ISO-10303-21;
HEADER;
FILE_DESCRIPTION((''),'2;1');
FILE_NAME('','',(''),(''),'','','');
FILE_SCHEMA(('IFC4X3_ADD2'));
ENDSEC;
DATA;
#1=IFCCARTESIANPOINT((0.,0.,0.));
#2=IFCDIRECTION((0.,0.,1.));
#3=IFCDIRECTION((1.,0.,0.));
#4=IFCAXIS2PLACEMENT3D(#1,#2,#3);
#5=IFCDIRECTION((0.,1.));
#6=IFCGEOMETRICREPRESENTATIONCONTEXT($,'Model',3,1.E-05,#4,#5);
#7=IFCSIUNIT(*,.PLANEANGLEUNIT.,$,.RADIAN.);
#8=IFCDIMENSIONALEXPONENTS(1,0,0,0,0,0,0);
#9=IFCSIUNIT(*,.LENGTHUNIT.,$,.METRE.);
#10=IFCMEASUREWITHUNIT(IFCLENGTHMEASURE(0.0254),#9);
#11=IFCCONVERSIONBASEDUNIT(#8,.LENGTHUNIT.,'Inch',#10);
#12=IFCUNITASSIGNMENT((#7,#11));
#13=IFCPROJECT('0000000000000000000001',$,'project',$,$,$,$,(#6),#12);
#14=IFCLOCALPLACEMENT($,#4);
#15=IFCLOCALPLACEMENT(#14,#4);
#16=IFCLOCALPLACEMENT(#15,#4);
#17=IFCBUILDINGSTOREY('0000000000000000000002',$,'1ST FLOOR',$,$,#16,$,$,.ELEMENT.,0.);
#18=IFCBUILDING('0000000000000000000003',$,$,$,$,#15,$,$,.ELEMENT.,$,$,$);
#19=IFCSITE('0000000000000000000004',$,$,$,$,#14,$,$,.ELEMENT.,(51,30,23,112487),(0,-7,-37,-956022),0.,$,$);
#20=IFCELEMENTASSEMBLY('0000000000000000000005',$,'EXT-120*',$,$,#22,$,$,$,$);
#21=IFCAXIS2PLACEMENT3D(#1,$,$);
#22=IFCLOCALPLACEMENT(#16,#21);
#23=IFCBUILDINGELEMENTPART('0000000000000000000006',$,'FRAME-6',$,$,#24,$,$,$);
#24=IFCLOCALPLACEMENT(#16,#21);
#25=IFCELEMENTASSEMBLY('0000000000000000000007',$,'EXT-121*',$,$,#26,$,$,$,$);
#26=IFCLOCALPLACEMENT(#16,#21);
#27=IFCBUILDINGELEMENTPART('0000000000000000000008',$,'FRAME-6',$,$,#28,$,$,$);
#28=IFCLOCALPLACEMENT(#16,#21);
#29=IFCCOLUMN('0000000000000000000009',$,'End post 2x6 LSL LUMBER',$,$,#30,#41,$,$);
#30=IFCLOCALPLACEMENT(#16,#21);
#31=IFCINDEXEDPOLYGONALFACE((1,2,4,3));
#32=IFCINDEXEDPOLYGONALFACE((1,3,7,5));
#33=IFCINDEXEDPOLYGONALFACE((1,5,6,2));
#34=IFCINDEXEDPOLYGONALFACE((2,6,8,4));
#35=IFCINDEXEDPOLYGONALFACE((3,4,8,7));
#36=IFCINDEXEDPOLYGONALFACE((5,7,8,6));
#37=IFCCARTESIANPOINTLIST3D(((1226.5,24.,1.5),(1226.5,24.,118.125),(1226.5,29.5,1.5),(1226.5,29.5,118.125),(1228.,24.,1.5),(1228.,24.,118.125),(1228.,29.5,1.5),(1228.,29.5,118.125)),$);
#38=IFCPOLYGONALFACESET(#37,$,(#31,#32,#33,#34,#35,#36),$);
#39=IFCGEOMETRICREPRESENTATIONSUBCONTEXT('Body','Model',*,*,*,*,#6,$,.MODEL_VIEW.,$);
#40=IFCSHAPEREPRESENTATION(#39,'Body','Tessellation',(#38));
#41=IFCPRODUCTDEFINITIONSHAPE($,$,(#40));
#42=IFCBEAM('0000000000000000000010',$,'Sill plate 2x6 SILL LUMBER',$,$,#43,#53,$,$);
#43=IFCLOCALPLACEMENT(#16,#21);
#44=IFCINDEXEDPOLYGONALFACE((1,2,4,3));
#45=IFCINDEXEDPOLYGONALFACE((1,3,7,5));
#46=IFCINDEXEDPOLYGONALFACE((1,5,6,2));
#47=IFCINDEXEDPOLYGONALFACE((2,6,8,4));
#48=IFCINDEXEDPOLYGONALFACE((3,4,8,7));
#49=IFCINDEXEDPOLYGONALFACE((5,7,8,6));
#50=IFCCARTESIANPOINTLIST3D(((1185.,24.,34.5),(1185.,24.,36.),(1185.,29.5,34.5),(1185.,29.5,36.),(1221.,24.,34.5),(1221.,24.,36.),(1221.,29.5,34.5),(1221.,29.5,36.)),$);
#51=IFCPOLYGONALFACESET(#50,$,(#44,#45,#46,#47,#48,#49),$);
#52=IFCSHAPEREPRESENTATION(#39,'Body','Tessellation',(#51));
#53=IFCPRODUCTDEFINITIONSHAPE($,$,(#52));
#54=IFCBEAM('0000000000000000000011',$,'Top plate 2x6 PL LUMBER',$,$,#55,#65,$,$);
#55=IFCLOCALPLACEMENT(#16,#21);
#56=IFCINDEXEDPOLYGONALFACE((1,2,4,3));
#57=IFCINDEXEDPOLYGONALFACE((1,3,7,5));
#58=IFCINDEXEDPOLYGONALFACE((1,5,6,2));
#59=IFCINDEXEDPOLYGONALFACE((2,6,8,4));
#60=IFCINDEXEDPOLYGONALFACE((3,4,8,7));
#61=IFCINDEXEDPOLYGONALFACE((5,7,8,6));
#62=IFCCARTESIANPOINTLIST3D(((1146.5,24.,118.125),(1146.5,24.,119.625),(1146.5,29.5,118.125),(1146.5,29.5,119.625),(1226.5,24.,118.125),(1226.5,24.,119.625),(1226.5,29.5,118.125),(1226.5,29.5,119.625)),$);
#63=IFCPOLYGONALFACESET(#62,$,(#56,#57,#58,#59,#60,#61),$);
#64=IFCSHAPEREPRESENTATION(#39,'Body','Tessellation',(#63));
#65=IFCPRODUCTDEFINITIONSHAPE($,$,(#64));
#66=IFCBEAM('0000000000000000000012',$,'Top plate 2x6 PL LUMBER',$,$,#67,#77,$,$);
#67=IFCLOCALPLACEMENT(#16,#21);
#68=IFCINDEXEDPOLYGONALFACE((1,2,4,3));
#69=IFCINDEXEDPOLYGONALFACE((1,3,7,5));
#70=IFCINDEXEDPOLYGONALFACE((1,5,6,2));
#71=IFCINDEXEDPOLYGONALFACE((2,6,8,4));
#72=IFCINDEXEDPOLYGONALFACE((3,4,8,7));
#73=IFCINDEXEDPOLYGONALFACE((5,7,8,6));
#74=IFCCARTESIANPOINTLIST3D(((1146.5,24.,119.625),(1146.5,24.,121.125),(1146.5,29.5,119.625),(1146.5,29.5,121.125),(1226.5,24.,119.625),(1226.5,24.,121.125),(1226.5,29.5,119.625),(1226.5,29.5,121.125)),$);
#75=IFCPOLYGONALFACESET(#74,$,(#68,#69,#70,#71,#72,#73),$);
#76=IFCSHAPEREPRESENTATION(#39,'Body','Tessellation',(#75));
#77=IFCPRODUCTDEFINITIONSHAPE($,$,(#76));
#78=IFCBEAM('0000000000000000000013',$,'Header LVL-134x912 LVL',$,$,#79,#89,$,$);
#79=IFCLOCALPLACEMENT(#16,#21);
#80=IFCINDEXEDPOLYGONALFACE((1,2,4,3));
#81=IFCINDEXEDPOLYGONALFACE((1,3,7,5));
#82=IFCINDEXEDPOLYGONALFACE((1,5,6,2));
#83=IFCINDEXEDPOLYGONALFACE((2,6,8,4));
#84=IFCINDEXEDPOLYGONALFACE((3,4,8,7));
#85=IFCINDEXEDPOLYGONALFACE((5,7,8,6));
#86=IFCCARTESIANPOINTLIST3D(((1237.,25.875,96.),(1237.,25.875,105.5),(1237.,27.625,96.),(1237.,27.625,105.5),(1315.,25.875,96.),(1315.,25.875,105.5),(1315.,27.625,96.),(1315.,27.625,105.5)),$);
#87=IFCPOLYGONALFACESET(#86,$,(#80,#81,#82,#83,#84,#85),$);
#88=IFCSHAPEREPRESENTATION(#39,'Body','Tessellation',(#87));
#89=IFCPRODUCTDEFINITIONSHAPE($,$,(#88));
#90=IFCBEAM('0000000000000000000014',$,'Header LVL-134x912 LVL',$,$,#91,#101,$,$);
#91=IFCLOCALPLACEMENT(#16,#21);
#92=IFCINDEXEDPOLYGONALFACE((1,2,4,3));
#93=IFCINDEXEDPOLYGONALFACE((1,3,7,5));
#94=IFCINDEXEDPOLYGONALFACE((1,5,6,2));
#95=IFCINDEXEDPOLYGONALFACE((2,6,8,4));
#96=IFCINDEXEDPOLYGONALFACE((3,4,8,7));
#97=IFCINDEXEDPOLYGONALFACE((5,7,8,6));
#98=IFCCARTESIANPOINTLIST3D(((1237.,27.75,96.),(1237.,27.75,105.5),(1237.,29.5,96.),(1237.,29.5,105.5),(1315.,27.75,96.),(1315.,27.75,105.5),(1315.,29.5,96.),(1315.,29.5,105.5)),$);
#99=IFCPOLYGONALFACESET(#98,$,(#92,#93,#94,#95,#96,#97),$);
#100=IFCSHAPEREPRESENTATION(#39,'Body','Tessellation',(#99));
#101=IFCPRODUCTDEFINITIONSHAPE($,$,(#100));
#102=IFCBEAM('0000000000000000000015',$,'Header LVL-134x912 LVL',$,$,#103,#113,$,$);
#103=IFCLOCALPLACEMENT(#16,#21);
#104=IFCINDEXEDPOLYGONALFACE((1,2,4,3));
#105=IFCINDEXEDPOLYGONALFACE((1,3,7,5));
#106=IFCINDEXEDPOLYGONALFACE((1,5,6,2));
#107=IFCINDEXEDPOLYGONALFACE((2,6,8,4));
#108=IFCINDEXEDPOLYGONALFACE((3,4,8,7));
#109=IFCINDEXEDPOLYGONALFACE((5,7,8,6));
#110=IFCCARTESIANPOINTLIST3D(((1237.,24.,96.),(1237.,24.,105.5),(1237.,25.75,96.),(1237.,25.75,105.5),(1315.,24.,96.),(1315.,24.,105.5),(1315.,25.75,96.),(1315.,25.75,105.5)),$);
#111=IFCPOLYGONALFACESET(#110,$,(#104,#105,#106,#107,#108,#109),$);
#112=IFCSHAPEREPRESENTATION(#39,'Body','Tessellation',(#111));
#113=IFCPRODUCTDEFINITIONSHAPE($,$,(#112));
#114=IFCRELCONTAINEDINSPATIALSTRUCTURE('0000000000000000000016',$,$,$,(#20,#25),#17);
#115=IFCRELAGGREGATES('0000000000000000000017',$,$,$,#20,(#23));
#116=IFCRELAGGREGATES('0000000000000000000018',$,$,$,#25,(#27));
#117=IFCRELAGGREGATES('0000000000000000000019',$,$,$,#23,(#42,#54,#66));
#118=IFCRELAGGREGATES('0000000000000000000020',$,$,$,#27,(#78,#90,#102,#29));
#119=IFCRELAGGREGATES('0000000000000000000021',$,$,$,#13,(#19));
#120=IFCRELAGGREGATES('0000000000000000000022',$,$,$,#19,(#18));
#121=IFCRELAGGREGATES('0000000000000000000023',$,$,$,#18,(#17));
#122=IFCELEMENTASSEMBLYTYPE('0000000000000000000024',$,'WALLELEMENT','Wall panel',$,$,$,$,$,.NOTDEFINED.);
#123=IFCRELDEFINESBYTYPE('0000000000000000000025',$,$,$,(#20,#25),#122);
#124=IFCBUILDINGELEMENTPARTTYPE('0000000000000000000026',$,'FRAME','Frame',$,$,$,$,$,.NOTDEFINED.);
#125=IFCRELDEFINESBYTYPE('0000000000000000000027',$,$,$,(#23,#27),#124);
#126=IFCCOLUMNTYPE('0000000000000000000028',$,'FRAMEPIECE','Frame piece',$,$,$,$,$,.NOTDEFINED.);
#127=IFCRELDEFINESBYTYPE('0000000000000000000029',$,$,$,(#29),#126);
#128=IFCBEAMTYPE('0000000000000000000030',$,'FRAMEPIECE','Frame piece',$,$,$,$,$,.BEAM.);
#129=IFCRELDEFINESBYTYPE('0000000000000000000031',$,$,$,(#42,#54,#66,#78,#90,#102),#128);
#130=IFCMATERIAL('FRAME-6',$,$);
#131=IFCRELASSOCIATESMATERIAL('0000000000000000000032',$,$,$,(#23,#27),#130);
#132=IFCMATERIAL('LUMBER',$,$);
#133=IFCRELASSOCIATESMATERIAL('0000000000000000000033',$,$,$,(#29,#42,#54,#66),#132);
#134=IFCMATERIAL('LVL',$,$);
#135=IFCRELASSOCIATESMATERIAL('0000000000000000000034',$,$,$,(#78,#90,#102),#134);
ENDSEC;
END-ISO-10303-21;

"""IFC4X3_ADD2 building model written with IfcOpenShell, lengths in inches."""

from ifc_helpers import new_model, entity, si_unit, converted_unit, direction, frame, origin_with_axes, origin_2d_with_axis, place, context, subcontext, project, spatial, rectangle, extrude, material, type_object, element, aggregate, save


model = new_model("IFC4X3_ADD2")

# Units and contexts
model_context = context("Model", 3, precision=1e-05, world=origin_with_axes(), true_north=direction((0.0, 1.0)))
body_context = subcontext(model_context, "Body", "Model", "MODEL_VIEW")
ifc_project = project(units=[si_unit("PLANEANGLEUNIT", "RADIAN"), converted_unit("LENGTHUNIT", "Inch", entity("IfcLengthMeasure", 0.0254), si_unit("LENGTHUNIT", "METRE"), dimensions=[1, 0, 0, 0, 0, 0, 0])], contexts=[model_context])

# Site, building, storey
site_placement = place(None, origin_with_axes())
site = spatial("IfcSite", under=ifc_project, at=site_placement, CompositionType="ELEMENT", RefLatitude=(51, 30, 23, 112487), RefLongitude=(0, -7, -37, -956022), RefElevation=0.0)
building_placement = place(site_placement, origin_with_axes())
building = spatial("IfcBuilding", under=site, at=building_placement, CompositionType="ELEMENT")
storey_placement = place(building_placement, origin_with_axes())
storey = spatial("IfcBuildingStorey", under=building, at=storey_placement, Name="1ST FLOOR", CompositionType="ELEMENT", Elevation=0.0)

# Element assemblies, building element parts, column
element_assembly_type = type_object("IfcElementAssemblyType", Name="WALLELEMENT", Description="Wall panel", PredefinedType="NOTDEFINED")
assembly_1_placement = place(storey_placement, origin_with_axes())
assembly_1 = element("IfcElementAssembly", 1, at=assembly_1_placement, inside=storey, type_object=element_assembly_type, Name="EXT-120*")
ifc_material_1 = material(Name="FRAME-6")
building_element_part_type = type_object("IfcBuildingElementPartType", Name="FRAME", Description="Frame", PredefinedType="NOTDEFINED")
building_element_part_1_placement = place(storey_placement, origin_with_axes())
building_element_part_1 = element("IfcBuildingElementPart", 2, at=building_element_part_1_placement, type_object=building_element_part_type, material=ifc_material_1, Name="FRAME-6")
aggregate(assembly_1, [building_element_part_1])
ifc_material_2 = material(Name="LUMBER")
column_type = type_object("IfcColumnType", Name="FRAMEPIECE", Description="Frame piece", PredefinedType="NOTDEFINED")
assembly_2_placement = place(storey_placement, origin_with_axes())
assembly_2 = element("IfcElementAssembly", 3, at=assembly_2_placement, inside=storey, type_object=element_assembly_type, Name="EXT-121*")
building_element_part_2_placement = place(storey_placement, origin_with_axes())
building_element_part_2 = element("IfcBuildingElementPart", 4, at=building_element_part_2_placement, type_object=building_element_part_type, material=ifc_material_1, Name="FRAME-6")
aggregate(assembly_2, [building_element_part_2])
column_1_placement = place(storey_placement, frame((1227.25, 26.75, 118.125), z_axis=(0.0, 0.0, -1.0), x_axis=(1.0, 0.0, 0.0)))
column_1 = element("IfcColumn", 5, at=column_1_placement, type_object=column_type, material=ifc_material_2, Name="End post 2x6 LSL LUMBER", context=body_context, shape_type="SweptSolid", body=[
    extrude(rectangle(XDim=1.5, YDim=5.5, at=origin_2d_with_axis()), origin_with_axes(), (0.0, 0.0, 1.0), 116.625),
])

# Beams
beam_type = type_object("IfcBeamType", Name="FRAMEPIECE", Description="Frame piece", PredefinedType="BEAM")
beam_1_placement = place(storey_placement, frame((1221.0, 26.75, 35.25), z_axis=(-1.0, 0.0, 0.0), x_axis=(0.0, 0.0, -1.0)))
beam_1 = element("IfcBeam", 6, at=beam_1_placement, type_object=beam_type, material=ifc_material_2, Name="Sill plate 2x6 SILL LUMBER", context=body_context, shape_type="SweptSolid", body=[
    extrude(rectangle(XDim=1.5, YDim=5.5, at=origin_2d_with_axis()), origin_with_axes(), (0.0, 0.0, 1.0), 36.0),
])
beam_2_placement = place(storey_placement, frame((1226.5, 26.75, 118.875), z_axis=(-1.0, 0.0, 0.0), x_axis=(0.0, 0.0, -1.0)))
beam_2 = element("IfcBeam", 7, at=beam_2_placement, type_object=beam_type, material=ifc_material_2, Name="Top plate 2x6 PL LUMBER", context=body_context, shape_type="SweptSolid", body=[
    extrude(rectangle(XDim=1.5, YDim=5.5, at=origin_2d_with_axis()), origin_with_axes(), (0.0, 0.0, 1.0), 80.0),
])
beam_3_placement = place(storey_placement, frame((1226.5, 26.75, 120.375), z_axis=(-1.0, 0.0, 0.0), x_axis=(0.0, 0.0, -1.0)))
beam_3 = element("IfcBeam", 8, at=beam_3_placement, type_object=beam_type, material=ifc_material_2, Name="Top plate 2x6 PL LUMBER", context=body_context, shape_type="SweptSolid", body=[
    extrude(rectangle(XDim=1.5, YDim=5.5, at=origin_2d_with_axis()), origin_with_axes(), (0.0, 0.0, 1.0), 80.0),
])
aggregate(building_element_part_1, [beam_1, beam_2, beam_3])
ifc_material_3 = material(Name="LVL")
beam_4_placement = place(storey_placement, frame((1237.0, 26.75, 100.75), z_axis=(1.0, 0.0, 0.0), x_axis=(0.0, 1.0, 0.0)))
beam_4 = element("IfcBeam", 9, at=beam_4_placement, type_object=beam_type, material=ifc_material_3, Name="Header LVL-134x912 LVL", context=body_context, shape_type="SweptSolid", body=[
    extrude(rectangle(XDim=1.75, YDim=9.5, at=origin_2d_with_axis()), origin_with_axes(), (0.0, 0.0, 1.0), 78.0),
])
beam_5_placement = place(storey_placement, frame((1237.0, 28.625, 100.75), z_axis=(1.0, 0.0, 0.0), x_axis=(0.0, 1.0, 0.0)))
beam_5 = element("IfcBeam", 10, at=beam_5_placement, type_object=beam_type, material=ifc_material_3, Name="Header LVL-134x912 LVL", context=body_context, shape_type="SweptSolid", body=[
    extrude(rectangle(XDim=1.75, YDim=9.5, at=origin_2d_with_axis()), origin_with_axes(), (0.0, 0.0, 1.0), 78.0),
])
beam_6_placement = place(storey_placement, frame((1237.0, 24.875, 100.75), z_axis=(1.0, 0.0, 0.0), x_axis=(0.0, 1.0, 0.0)))
beam_6 = element("IfcBeam", 11, at=beam_6_placement, type_object=beam_type, material=ifc_material_3, Name="Header LVL-134x912 LVL", context=body_context, shape_type="SweptSolid", body=[
    extrude(rectangle(XDim=1.75, YDim=9.5, at=origin_2d_with_axis()), origin_with_axes(), (0.0, 0.0, 1.0), 78.0),
])
aggregate(building_element_part_2, [beam_4, beam_5, beam_6, column_1])

save(model, "model.ifc")
